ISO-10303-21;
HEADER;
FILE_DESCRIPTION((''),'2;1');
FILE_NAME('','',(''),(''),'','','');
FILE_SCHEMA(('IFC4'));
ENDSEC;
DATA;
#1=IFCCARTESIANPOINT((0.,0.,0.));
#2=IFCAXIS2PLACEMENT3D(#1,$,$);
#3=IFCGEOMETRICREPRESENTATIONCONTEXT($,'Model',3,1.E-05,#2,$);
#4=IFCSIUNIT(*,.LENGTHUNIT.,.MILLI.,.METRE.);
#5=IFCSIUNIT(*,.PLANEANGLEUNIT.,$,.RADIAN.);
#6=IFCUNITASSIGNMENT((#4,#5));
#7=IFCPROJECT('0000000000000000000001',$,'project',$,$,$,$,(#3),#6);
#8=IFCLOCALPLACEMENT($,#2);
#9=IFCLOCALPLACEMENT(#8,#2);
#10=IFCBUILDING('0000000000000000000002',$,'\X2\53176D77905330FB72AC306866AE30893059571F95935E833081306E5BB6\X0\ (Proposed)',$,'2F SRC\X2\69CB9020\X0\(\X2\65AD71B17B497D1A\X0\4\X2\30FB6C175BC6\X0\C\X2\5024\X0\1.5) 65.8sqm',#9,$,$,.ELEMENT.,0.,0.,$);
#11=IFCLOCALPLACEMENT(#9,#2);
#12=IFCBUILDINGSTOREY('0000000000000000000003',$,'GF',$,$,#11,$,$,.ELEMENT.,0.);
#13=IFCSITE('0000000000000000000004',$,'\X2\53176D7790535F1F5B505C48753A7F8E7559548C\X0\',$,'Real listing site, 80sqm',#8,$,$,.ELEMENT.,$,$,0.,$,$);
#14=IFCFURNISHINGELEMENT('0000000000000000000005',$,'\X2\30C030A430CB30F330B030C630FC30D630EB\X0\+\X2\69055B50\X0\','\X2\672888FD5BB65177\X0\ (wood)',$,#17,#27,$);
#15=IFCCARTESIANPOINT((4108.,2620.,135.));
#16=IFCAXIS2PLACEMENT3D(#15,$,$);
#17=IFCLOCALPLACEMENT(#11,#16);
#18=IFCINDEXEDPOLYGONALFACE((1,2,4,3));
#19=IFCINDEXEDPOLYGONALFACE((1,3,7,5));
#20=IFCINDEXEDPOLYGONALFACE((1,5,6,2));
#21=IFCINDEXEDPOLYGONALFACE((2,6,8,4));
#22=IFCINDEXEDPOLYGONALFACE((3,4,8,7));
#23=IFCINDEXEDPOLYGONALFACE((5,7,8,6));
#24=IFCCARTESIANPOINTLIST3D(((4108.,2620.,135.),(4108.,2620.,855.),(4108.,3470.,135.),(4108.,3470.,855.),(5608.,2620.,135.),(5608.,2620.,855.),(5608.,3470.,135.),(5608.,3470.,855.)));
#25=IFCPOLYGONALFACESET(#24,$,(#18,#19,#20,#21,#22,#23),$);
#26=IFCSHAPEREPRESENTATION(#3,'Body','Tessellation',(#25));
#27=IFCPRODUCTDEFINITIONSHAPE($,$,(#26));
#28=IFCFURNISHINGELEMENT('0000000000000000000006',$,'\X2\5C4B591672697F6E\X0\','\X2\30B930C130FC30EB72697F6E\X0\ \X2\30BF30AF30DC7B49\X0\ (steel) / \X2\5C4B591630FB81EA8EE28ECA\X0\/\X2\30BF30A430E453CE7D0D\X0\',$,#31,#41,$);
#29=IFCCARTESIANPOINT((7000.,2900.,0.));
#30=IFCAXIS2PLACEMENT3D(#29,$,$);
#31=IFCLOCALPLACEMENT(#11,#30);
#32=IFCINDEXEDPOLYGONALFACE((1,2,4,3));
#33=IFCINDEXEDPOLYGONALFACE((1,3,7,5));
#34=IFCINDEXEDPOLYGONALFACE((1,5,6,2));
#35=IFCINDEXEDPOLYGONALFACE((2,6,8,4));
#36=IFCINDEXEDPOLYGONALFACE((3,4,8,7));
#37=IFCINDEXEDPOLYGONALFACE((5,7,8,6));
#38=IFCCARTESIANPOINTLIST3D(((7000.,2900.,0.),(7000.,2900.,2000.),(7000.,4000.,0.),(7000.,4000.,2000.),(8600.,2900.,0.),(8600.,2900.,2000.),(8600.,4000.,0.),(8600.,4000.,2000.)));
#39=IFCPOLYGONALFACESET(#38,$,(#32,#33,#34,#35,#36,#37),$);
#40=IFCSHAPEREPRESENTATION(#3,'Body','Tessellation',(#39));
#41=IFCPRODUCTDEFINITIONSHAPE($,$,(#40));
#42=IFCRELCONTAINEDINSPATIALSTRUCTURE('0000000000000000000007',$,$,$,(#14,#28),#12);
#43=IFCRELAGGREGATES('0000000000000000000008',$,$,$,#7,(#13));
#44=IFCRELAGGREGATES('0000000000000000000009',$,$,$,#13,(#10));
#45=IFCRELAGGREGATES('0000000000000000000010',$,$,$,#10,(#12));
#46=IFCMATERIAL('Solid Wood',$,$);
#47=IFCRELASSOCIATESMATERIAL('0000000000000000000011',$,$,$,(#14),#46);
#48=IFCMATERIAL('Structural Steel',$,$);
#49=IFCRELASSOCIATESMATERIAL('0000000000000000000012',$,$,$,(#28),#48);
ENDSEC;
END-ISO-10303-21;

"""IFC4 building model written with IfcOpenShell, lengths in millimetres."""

from ifc_helpers import new_model, si_unit, frame, frame_2d, origin, place, context, project, spatial, rectangle, extrude, material, element, save


model = new_model("IFC4")

# Units and contexts
model_context = context("Model", 3, precision=1e-05, world=origin())
ifc_project = project(units=[si_unit("LENGTHUNIT", "METRE", prefix="MILLI"), si_unit("PLANEANGLEUNIT", "RADIAN")], contexts=[model_context])

# Site, building, storey
site_placement = place(None, origin())
site = spatial("IfcSite", under=ifc_project, at=site_placement, Name="北海道弟子屈町美留和", ObjectType="Real listing site, 80sqm", CompositionType="ELEMENT", RefElevation=0.0)
building_placement = place(site_placement, origin())
building = spatial("IfcBuilding", under=site, at=building_placement, Name="北海道・犬と暮らす土間広めの家 (Proposed)", ObjectType="2F SRC構造(断熱等級4・気密C値1.5) 65.8sqm", CompositionType="ELEMENT", ElevationOfRefHeight=0.0, ElevationOfTerrain=0.0)
storey_placement = place(building_placement, origin())
storey = spatial("IfcBuildingStorey", under=building, at=storey_placement, Name="GF", CompositionType="ELEMENT", Elevation=0.0)

# Shared definitions
ifc_material_1 = material(Name="Solid Wood")

# Shared definitions
ifc_material_2 = material(Name="Structural Steel")

# Furnishing elements
furnishing_1_placement = place(storey_placement, frame((4108.0, 2620.0, 135.0)))
element("IfcFurnishingElement", 1, at=furnishing_1_placement, inside=storey, material=ifc_material_1, Name="ダイニングテーブル+椅子", Description="木製家具 (wood)", context=model_context, shape_type="SweptSolid", body=[
    extrude(rectangle(XDim=1500.0, YDim=850.0, at=frame_2d((750.0, 425.0))), frame((4108.0, 2620.0, 135.0)), (0.0, 0.0, 1.0), 720.0),
])
furnishing_2_placement = place(storey_placement, frame((7000.0, 2900.0, 0.0)))
element("IfcFurnishingElement", 2, at=furnishing_2_placement, inside=storey, material=ifc_material_2, Name="屋外物置", Description="スチール物置 タクボ等 (steel) / 屋外・自転車/タイヤ収納", context=model_context, shape_type="SweptSolid", body=[
    extrude(rectangle(XDim=1600.0, YDim=1100.0, at=frame_2d((800.0, 550.0))), frame((7000.0, 2900.0, 0.0)), (0.0, 0.0, 1.0), 2000.0),
])

save(model, "model.ifc")
